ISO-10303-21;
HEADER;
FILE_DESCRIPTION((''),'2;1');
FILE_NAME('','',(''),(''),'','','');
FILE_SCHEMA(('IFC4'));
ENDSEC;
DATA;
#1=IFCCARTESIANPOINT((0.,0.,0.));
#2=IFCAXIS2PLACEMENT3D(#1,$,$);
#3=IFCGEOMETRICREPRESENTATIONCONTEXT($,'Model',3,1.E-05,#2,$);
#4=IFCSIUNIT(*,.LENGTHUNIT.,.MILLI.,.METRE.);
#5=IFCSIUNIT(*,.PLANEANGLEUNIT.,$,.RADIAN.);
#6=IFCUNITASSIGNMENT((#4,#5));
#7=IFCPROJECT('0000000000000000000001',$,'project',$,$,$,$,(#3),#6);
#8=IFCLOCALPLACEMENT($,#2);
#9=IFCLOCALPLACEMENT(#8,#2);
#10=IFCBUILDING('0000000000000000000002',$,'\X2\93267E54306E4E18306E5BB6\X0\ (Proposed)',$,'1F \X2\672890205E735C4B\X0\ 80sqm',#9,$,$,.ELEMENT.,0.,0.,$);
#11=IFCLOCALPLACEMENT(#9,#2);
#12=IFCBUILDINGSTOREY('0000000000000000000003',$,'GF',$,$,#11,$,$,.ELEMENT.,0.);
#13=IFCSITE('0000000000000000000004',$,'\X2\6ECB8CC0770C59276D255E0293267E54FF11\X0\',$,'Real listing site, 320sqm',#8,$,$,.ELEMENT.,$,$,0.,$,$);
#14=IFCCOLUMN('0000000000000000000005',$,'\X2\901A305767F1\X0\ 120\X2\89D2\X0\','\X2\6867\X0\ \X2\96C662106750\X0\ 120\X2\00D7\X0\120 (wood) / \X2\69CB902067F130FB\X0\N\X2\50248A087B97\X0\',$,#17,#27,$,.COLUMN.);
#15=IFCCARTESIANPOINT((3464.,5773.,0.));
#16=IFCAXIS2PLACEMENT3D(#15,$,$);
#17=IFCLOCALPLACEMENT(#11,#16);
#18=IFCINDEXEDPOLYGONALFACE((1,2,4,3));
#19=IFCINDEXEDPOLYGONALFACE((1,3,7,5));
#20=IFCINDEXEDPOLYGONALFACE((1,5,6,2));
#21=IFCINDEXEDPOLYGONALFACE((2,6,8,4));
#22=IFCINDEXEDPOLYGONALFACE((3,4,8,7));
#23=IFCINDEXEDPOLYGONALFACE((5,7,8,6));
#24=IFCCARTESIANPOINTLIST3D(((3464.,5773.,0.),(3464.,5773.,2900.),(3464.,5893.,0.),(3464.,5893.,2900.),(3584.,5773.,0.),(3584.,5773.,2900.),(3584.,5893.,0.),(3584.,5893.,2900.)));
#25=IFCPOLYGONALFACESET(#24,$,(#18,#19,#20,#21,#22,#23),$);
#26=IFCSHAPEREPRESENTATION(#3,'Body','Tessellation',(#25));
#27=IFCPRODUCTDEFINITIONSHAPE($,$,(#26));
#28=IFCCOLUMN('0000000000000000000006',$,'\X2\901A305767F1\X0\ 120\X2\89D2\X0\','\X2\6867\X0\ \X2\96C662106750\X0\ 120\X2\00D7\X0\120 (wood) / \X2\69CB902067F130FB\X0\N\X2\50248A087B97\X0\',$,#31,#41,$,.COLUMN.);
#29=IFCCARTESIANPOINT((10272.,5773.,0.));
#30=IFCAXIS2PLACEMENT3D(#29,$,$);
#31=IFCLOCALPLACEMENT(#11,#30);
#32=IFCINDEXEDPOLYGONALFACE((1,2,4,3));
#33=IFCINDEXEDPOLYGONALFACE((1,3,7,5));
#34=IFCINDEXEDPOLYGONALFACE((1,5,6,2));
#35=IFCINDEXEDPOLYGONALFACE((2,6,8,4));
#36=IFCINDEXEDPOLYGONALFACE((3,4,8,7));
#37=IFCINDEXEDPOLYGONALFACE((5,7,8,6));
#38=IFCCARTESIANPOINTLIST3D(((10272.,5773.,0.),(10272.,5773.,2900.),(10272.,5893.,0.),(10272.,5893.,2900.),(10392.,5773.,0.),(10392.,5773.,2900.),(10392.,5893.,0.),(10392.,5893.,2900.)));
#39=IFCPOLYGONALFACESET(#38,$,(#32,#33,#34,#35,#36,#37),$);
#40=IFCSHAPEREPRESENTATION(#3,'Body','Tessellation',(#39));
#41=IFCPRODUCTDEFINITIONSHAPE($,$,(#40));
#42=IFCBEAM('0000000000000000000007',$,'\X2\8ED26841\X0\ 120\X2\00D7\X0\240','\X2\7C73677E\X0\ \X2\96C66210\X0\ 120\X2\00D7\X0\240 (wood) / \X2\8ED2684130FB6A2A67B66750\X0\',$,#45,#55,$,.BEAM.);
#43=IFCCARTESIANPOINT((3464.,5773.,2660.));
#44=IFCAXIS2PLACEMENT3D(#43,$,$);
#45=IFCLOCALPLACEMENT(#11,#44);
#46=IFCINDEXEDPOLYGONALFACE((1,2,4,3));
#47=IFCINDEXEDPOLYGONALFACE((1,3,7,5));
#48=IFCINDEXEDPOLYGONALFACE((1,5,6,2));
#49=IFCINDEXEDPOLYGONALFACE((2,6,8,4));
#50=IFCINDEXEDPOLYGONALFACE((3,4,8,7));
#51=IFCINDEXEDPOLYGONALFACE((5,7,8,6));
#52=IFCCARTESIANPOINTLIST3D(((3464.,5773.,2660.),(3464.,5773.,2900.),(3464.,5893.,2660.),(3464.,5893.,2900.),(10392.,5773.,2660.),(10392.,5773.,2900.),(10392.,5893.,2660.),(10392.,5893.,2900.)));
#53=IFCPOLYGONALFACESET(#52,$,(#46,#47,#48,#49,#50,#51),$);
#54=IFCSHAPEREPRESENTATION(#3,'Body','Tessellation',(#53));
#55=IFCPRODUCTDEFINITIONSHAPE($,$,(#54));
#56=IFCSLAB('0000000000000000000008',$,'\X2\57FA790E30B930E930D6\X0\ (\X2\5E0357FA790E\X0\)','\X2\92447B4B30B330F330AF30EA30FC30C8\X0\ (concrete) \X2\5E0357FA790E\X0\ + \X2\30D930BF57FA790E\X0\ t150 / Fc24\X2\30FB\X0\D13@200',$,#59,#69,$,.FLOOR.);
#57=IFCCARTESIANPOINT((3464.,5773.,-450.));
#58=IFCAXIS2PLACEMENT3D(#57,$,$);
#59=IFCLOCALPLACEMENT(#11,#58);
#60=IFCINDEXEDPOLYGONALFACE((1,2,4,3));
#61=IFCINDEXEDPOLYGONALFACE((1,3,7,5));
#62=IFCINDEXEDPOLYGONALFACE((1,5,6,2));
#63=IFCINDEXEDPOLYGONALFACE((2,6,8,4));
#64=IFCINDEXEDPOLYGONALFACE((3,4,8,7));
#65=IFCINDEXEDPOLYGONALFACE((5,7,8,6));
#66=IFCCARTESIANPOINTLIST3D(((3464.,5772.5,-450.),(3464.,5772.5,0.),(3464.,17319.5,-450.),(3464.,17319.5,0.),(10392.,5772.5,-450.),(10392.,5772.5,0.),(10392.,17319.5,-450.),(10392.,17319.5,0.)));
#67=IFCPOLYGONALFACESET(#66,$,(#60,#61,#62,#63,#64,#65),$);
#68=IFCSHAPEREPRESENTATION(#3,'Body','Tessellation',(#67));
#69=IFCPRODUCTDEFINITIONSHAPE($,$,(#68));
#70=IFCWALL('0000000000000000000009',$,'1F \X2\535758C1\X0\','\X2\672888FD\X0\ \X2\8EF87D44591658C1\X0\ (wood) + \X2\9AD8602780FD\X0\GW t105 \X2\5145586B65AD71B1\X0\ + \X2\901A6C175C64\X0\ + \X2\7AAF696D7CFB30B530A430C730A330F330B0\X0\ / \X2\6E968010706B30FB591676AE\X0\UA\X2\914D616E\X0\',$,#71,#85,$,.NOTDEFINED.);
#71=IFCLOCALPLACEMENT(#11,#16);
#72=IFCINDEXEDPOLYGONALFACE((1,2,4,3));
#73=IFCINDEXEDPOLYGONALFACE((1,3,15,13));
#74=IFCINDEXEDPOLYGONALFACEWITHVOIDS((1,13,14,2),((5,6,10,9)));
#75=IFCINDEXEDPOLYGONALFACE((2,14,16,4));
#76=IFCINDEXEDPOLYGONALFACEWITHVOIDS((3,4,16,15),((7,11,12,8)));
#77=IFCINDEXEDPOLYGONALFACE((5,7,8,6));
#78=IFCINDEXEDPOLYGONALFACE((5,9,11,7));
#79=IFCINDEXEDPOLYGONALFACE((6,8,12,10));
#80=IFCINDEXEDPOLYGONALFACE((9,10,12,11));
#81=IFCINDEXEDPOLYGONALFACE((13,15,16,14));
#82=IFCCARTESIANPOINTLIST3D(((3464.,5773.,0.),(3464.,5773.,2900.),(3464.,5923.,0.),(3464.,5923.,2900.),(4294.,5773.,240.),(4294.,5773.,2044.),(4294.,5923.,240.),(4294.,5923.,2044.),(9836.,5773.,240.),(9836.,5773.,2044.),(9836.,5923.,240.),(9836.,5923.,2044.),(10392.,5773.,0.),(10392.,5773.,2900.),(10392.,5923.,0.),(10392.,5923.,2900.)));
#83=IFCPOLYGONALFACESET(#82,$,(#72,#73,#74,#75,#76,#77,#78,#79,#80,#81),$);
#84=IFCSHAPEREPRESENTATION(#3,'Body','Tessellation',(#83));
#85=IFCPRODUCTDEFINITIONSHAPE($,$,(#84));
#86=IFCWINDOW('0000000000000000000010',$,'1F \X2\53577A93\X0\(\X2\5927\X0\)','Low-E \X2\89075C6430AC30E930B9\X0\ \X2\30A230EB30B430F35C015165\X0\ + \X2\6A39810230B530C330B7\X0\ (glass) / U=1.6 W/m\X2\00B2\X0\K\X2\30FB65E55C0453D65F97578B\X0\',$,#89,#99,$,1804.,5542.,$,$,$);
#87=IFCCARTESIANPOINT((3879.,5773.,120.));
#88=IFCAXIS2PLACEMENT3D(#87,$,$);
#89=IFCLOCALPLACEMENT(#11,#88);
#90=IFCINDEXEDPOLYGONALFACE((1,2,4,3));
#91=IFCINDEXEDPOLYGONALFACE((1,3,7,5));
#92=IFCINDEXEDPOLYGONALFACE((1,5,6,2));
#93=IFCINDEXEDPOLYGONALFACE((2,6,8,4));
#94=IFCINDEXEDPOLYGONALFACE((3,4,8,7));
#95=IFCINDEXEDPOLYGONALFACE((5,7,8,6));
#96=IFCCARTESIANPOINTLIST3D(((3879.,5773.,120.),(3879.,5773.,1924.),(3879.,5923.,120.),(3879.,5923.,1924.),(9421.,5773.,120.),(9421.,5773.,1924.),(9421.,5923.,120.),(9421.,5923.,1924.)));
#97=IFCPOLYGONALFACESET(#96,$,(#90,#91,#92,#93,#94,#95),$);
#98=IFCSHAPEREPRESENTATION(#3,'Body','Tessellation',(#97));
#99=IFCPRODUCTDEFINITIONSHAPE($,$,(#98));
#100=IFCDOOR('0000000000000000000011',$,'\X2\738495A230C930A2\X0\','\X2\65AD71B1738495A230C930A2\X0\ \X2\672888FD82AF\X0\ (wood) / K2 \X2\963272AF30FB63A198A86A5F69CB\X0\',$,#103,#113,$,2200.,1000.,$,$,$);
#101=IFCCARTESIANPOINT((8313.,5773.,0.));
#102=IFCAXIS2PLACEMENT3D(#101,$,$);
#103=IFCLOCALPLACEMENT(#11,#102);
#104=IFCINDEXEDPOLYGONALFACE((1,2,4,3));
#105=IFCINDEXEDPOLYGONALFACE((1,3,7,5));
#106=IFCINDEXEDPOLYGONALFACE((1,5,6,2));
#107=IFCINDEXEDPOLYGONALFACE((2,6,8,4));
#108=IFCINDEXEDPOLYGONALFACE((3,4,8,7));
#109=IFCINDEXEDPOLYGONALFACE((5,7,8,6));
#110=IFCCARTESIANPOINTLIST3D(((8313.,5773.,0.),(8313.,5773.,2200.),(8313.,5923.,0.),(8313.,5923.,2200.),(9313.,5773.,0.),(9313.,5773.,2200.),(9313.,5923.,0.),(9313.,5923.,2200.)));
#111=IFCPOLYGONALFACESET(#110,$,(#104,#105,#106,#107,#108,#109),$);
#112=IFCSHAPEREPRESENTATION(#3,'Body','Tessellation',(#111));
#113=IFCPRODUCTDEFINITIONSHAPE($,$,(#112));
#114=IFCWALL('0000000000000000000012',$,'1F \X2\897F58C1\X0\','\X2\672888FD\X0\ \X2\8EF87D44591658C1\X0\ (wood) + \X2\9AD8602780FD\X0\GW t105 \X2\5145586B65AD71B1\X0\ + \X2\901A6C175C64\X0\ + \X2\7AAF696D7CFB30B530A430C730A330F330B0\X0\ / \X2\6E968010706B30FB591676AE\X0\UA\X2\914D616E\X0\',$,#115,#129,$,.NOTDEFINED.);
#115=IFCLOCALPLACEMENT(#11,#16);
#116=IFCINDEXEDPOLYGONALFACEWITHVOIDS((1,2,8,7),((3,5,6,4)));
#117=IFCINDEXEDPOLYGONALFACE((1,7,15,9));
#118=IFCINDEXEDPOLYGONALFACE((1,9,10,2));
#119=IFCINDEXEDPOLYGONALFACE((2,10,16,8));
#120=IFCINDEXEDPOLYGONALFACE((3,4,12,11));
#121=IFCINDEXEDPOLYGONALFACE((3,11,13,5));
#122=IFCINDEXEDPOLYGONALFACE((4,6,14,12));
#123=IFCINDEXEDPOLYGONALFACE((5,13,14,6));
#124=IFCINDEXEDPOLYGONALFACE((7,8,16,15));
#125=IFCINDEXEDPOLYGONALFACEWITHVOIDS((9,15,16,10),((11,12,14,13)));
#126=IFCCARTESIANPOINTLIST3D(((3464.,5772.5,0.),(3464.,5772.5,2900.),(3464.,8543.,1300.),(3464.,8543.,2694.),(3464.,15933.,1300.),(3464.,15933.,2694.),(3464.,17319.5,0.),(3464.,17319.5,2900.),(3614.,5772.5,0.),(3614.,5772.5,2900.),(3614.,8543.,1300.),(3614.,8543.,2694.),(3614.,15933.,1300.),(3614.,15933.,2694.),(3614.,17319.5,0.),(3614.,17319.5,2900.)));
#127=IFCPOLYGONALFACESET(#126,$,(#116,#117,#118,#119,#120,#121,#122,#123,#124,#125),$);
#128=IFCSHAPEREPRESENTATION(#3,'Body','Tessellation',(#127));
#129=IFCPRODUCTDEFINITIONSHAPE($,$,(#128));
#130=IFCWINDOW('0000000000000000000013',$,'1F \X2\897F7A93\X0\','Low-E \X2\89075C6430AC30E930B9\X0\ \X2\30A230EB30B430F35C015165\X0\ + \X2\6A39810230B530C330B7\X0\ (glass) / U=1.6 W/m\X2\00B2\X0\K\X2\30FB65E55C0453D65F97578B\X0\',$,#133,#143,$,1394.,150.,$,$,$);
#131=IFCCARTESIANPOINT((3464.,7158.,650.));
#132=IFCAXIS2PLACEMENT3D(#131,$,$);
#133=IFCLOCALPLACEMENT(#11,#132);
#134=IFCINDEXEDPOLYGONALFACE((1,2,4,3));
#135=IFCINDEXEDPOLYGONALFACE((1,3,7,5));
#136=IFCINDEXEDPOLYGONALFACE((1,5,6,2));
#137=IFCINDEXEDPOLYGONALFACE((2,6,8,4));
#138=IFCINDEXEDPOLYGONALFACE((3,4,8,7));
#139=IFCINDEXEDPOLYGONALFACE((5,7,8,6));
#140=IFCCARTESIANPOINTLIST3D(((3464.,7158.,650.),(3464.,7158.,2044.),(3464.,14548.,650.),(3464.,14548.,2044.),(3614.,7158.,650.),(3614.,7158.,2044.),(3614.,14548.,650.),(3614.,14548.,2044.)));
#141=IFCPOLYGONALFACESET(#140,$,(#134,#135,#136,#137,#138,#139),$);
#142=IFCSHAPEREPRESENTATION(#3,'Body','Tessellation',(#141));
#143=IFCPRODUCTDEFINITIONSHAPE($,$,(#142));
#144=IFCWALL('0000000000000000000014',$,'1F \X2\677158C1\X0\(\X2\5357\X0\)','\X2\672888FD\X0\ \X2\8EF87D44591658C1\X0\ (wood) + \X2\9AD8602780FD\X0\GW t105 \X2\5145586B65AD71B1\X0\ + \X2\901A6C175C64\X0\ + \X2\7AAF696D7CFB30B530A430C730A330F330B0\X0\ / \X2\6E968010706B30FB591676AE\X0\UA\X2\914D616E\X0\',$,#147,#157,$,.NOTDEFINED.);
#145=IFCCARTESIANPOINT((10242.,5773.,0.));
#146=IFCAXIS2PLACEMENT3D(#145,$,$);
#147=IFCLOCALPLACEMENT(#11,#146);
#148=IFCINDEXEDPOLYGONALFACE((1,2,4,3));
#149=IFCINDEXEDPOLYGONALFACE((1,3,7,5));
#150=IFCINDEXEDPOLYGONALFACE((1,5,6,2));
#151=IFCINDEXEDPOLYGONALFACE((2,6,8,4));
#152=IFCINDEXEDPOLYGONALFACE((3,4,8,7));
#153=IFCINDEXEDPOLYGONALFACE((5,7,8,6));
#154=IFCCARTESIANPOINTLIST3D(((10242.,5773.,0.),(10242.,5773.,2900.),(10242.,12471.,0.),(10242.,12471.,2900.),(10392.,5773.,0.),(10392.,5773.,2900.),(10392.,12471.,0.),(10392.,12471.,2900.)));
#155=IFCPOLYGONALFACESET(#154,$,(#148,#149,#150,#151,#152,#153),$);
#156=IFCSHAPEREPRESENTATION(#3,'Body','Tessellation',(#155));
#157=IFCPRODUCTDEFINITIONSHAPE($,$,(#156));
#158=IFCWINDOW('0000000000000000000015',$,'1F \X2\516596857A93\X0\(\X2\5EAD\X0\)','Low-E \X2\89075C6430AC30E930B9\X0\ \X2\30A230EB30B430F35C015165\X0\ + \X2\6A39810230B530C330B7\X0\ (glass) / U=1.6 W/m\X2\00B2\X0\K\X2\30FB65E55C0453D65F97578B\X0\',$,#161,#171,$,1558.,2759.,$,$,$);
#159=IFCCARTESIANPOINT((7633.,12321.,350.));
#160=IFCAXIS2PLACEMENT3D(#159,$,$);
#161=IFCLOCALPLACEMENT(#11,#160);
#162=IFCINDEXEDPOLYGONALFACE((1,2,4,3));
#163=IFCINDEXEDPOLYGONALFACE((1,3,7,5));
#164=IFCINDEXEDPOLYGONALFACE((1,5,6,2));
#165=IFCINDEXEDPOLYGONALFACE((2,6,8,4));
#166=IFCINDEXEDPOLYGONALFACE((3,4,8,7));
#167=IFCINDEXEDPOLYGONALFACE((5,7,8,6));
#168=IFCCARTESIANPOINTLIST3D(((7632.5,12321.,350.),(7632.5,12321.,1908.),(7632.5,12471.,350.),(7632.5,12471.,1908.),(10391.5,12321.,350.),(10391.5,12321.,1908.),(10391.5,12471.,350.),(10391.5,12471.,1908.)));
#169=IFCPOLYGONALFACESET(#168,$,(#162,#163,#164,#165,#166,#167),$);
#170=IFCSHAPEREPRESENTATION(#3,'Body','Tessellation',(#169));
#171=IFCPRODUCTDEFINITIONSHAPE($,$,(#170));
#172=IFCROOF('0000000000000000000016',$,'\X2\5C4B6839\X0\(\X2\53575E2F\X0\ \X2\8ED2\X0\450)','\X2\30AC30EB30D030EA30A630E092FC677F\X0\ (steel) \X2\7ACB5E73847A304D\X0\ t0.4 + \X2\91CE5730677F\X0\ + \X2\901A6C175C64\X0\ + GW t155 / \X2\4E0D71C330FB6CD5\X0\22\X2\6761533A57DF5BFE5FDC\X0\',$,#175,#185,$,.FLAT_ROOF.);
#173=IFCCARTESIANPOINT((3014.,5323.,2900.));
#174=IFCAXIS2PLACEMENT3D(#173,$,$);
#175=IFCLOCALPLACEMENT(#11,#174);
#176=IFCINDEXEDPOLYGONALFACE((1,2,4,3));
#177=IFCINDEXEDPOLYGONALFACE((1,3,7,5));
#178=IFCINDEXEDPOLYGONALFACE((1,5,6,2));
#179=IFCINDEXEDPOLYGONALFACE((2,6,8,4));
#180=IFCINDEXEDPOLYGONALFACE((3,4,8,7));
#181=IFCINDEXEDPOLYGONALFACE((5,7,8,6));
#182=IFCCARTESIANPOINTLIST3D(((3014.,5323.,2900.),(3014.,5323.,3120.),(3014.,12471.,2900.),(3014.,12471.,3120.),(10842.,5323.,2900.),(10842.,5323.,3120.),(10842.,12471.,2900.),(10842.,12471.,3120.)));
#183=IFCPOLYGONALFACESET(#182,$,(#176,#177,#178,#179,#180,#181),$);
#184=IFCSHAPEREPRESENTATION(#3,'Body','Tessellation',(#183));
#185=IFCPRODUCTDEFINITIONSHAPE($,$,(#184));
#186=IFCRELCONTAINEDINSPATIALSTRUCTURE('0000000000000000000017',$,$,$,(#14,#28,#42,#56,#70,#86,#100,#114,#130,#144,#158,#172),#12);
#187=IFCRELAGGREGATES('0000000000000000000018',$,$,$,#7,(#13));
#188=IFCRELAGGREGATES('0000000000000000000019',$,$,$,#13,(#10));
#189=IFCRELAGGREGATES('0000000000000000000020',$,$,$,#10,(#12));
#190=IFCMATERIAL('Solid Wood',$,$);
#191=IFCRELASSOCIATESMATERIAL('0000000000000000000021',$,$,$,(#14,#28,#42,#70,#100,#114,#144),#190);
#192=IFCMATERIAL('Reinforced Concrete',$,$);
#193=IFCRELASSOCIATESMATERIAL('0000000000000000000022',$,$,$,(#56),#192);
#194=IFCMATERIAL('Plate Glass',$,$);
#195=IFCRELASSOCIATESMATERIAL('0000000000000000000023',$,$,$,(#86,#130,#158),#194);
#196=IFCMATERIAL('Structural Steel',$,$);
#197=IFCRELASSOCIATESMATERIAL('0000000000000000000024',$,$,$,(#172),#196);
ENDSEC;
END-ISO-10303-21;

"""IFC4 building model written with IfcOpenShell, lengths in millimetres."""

from ifc_helpers import new_model, si_unit, frame, frame_2d, origin, place, context, project, spatial, rectangle, extrude, material, element, fill, save


model = new_model("IFC4")

# Units and contexts
model_context = context("Model", 3, precision=1e-05, world=origin())
ifc_project = project(units=[si_unit("LENGTHUNIT", "METRE", prefix="MILLI"), si_unit("PLANEANGLEUNIT", "RADIAN")], contexts=[model_context])

# Site, building, storey
site_placement = place(None, origin())
site = spatial("IfcSite", under=ifc_project, at=site_placement, Name="滋賀県大津市錦織１", ObjectType="Real listing site, 320sqm", CompositionType="ELEMENT", RefElevation=0.0)
building_placement = place(site_placement, origin())
building = spatial("IfcBuilding", under=site, at=building_placement, Name="錦織の丘の家 (Proposed)", ObjectType="1F 木造平屋 80sqm", CompositionType="ELEMENT", ElevationOfRefHeight=0.0, ElevationOfTerrain=0.0)
storey_placement = place(building_placement, origin())
storey = spatial("IfcBuildingStorey", under=building, at=storey_placement, Name="GF", CompositionType="ELEMENT", Elevation=0.0)

# Columns
ifc_material_1 = material(Name="Solid Wood")
column_1_placement = place(storey_placement, frame((3464.0, 5773.0, 0.0)))
element("IfcColumn", 1, at=column_1_placement, inside=storey, material=ifc_material_1, Name="通し柱 120角", Description="桧 集成材 120×120 (wood) / 構造柱・N値計算", PredefinedType="COLUMN", context=model_context, shape_type="SweptSolid", body=[
    extrude(rectangle(XDim=120.0, YDim=120.0, at=frame_2d((60.0, 60.0))), frame((3464.0, 5773.0, 0.0)), (0.0, 0.0, 1.0), 2900.0),
])
column_2_placement = place(storey_placement, frame((10272.0, 5773.0, 0.0)))
element("IfcColumn", 2, at=column_2_placement, inside=storey, material=ifc_material_1, Name="通し柱 120角", Description="桧 集成材 120×120 (wood) / 構造柱・N値計算", PredefinedType="COLUMN", context=model_context, shape_type="SweptSolid", body=[
    extrude(rectangle(XDim=120.0, YDim=120.0, at=frame_2d((60.0, 60.0))), frame((10272.0, 5773.0, 0.0)), (0.0, 0.0, 1.0), 2900.0),
])

# Beam
beam_1_placement = place(storey_placement, frame((3464.0, 5773.0, 2660.0)))
element("IfcBeam", 3, at=beam_1_placement, inside=storey, material=ifc_material_1, Name="軒桁 120×240", Description="米松 集成 120×240 (wood) / 軒桁・横架材", PredefinedType="BEAM", context=model_context, shape_type="SweptSolid", body=[
    extrude(rectangle(XDim=6928.0, YDim=120.0, at=frame_2d((3464.0, 60.0))), frame((3464.0, 5773.0, 2660.0)), (0.0, 0.0, 1.0), 240.0),
])

# Slab
ifc_material_2 = material(Name="Reinforced Concrete")
slab_1_placement = place(storey_placement, frame((3464.0, 5773.0, -450.0)))
element("IfcSlab", 4, at=slab_1_placement, inside=storey, material=ifc_material_2, Name="基礎スラブ (布基礎)", Description="鉄筋コンクリート (concrete) 布基礎 + ベタ基礎 t150 / Fc24・D13@200", PredefinedType="FLOOR", context=model_context, shape_type="SweptSolid", body=[
    extrude(rectangle(XDim=6928.0, YDim=11547.0, at=frame_2d((3464.0, 5773.0))), frame((3464.0, 5773.0, -450.0)), (0.0, 0.0, 1.0), 450.0),
])

# Wall, openings, window, door
wall_1_placement = place(storey_placement, frame((3464.0, 5773.0, 0.0)))
wall_1 = element("IfcWall", 5, at=wall_1_placement, inside=storey, material=ifc_material_1, Name="1F 南壁", Description="木製 軸組外壁 (wood) + 高性能GW t105 充填断熱 + 通気層 + 窯業系サイディング / 準耐火・外皮UA配慮", PredefinedType="NOTDEFINED", context=model_context, shape_type="SweptSolid", body=[
    extrude(rectangle(XDim=6928.0, YDim=150.0, at=frame_2d((3464.0, 75.0))), frame((3464.0, 5773.0, 0.0)), (0.0, 0.0, 1.0), 2900.0),
])
opening_1_placement = place(storey_placement, frame((3879.0, 5773.0, 120.0)))
opening_1 = element("IfcOpeningElement", 6, at=opening_1_placement, cuts=wall_1, PredefinedType="NOTDEFINED", context=model_context, shape_type="SweptSolid", body=[
    extrude(rectangle(XDim=5542.0, YDim=150.0, at=frame_2d((2771.0, 75.0))), frame((3879.0, 5773.0, 120.0)), (0.0, 0.0, 1.0), 1804.0),
])
opening_2_placement = place(storey_placement, frame((8313.0, 5773.0, 0.0)))
opening_2 = element("IfcOpeningElement", 7, at=opening_2_placement, cuts=wall_1, PredefinedType="NOTDEFINED", context=model_context, shape_type="SweptSolid", body=[
    extrude(rectangle(XDim=1000.0, YDim=150.0, at=frame_2d((500.0, 75.0))), frame((8313.0, 5773.0, 0.0)), (0.0, 0.0, 1.0), 2200.0),
])
ifc_material_3 = material(Name="Plate Glass")
window_1_placement = place(storey_placement, frame((3879.0, 5773.0, 120.0)))
window_1 = element("IfcWindow", 8, at=window_1_placement, inside=storey, material=ifc_material_3, Name="1F 南窓(大)", Description="Low-E 複層ガラス アルゴン封入 + 樹脂サッシ (glass) / U=1.6 W/m²K・日射取得型", OverallHeight=1804.0, OverallWidth=5542.0, context=model_context, shape_type="SweptSolid", body=[
    extrude(rectangle(XDim=5542.0, YDim=150.0, at=frame_2d((2771.0, 75.0))), frame((3879.0, 5773.0, 120.0)), (0.0, 0.0, 1.0), 1804.0),
])
fill(opening_1, window_1)
door_1_placement = place(storey_placement, frame((8313.0, 5773.0, 0.0)))
door_1 = element("IfcDoor", 9, at=door_1_placement, inside=storey, material=ifc_material_1, Name="玄関ドア", Description="断熱玄関ドア 木製芯 (wood) / K2 防犯・採風機構", OverallHeight=2200.0, OverallWidth=1000.0, context=model_context, shape_type="SweptSolid", body=[
    extrude(rectangle(XDim=1000.0, YDim=150.0, at=frame_2d((500.0, 75.0))), frame((8313.0, 5773.0, 0.0)), (0.0, 0.0, 1.0), 2200.0),
])
fill(opening_2, door_1)

# Walls, openings, windows
wall_2_placement = place(storey_placement, frame((3464.0, 5773.0, 0.0)))
wall_2 = element("IfcWall", 10, at=wall_2_placement, inside=storey, material=ifc_material_1, Name="1F 西壁", Description="木製 軸組外壁 (wood) + 高性能GW t105 充填断熱 + 通気層 + 窯業系サイディング / 準耐火・外皮UA配慮", PredefinedType="NOTDEFINED", context=model_context, shape_type="SweptSolid", body=[
    extrude(rectangle(XDim=150.0, YDim=11547.0, at=frame_2d((75.0, 5773.0))), frame((3464.0, 5773.0, 0.0)), (0.0, 0.0, 1.0), 2900.0),
])
opening_3_placement = place(storey_placement, frame((3464.0, 7158.0, 650.0)))
opening_3 = element("IfcOpeningElement", 11, at=opening_3_placement, cuts=wall_2, PredefinedType="NOTDEFINED", context=model_context, shape_type="SweptSolid", body=[
    extrude(rectangle(XDim=150.0, YDim=7390.0, at=frame_2d((75.0, 3695.0))), frame((3464.0, 7158.0, 650.0)), (0.0, 0.0, 1.0), 1394.0),
])
window_2_placement = place(storey_placement, frame((3464.0, 7158.0, 650.0)))
window_2 = element("IfcWindow", 12, at=window_2_placement, inside=storey, material=ifc_material_3, Name="1F 西窓", Description="Low-E 複層ガラス アルゴン封入 + 樹脂サッシ (glass) / U=1.6 W/m²K・日射取得型", OverallHeight=1394.0, OverallWidth=150.0, context=model_context, shape_type="SweptSolid", body=[
    extrude(rectangle(XDim=150.0, YDim=7390.0, at=frame_2d((75.0, 3695.0))), frame((3464.0, 7158.0, 650.0)), (0.0, 0.0, 1.0), 1394.0),
])
fill(opening_3, window_2)
wall_3_placement = place(storey_placement, frame((10242.0, 5773.0, 0.0)))
wall_3 = element("IfcWall", 13, at=wall_3_placement, inside=storey, material=ifc_material_1, Name="1F 東壁(南)", Description="木製 軸組外壁 (wood) + 高性能GW t105 充填断熱 + 通気層 + 窯業系サイディング / 準耐火・外皮UA配慮", PredefinedType="NOTDEFINED", context=model_context, shape_type="SweptSolid", body=[
    extrude(rectangle(XDim=150.0, YDim=6698.0, at=frame_2d((75.0, 3349.0))), frame((10242.0, 5773.0, 0.0)), (0.0, 0.0, 1.0), 2900.0),
])
opening_4_placement = place(storey_placement, frame((7633.0, 12321.0, 350.0)))
opening_4 = element("IfcOpeningElement", 14, at=opening_4_placement, cuts=wall_3, PredefinedType="NOTDEFINED", context=model_context, shape_type="SweptSolid", body=[
    extrude(rectangle(XDim=2759.0, YDim=150.0, at=frame_2d((1379.0, 75.0))), frame((7633.0, 12321.0, 350.0)), (0.0, 0.0, 1.0), 1558.0),
])
window_3_placement = place(storey_placement, frame((7633.0, 12321.0, 350.0)))
window_3 = element("IfcWindow", 15, at=window_3_placement, inside=storey, material=ifc_material_3, Name="1F 入隅窓(庭)", Description="Low-E 複層ガラス アルゴン封入 + 樹脂サッシ (glass) / U=1.6 W/m²K・日射取得型", OverallHeight=1558.0, OverallWidth=2759.0, context=model_context, shape_type="SweptSolid", body=[
    extrude(rectangle(XDim=2759.0, YDim=150.0, at=frame_2d((1379.0, 75.0))), frame((7633.0, 12321.0, 350.0)), (0.0, 0.0, 1.0), 1558.0),
])
fill(opening_4, window_3)

# Roof
ifc_material_4 = material(Name="Structural Steel")
roof_placement = place(storey_placement, frame((3014.0, 5323.0, 2900.0)))
element("IfcRoof", 16, at=roof_placement, inside=storey, material=ifc_material_4, Name="屋根(南帯 軒450)", Description="ガルバリウム鋼板 (steel) 立平葺き t0.4 + 野地板 + 通気層 + GW t155 / 不燃・法22条区域対応", PredefinedType="FLAT_ROOF", context=model_context, shape_type="SweptSolid", body=[
    extrude(rectangle(XDim=7828.0, YDim=7148.0, at=frame_2d((3914.0, 3574.0))), frame((3014.0, 5323.0, 2900.0)), (0.0, 0.0, 1.0), 220.0),
])

save(model, "model.ifc")
